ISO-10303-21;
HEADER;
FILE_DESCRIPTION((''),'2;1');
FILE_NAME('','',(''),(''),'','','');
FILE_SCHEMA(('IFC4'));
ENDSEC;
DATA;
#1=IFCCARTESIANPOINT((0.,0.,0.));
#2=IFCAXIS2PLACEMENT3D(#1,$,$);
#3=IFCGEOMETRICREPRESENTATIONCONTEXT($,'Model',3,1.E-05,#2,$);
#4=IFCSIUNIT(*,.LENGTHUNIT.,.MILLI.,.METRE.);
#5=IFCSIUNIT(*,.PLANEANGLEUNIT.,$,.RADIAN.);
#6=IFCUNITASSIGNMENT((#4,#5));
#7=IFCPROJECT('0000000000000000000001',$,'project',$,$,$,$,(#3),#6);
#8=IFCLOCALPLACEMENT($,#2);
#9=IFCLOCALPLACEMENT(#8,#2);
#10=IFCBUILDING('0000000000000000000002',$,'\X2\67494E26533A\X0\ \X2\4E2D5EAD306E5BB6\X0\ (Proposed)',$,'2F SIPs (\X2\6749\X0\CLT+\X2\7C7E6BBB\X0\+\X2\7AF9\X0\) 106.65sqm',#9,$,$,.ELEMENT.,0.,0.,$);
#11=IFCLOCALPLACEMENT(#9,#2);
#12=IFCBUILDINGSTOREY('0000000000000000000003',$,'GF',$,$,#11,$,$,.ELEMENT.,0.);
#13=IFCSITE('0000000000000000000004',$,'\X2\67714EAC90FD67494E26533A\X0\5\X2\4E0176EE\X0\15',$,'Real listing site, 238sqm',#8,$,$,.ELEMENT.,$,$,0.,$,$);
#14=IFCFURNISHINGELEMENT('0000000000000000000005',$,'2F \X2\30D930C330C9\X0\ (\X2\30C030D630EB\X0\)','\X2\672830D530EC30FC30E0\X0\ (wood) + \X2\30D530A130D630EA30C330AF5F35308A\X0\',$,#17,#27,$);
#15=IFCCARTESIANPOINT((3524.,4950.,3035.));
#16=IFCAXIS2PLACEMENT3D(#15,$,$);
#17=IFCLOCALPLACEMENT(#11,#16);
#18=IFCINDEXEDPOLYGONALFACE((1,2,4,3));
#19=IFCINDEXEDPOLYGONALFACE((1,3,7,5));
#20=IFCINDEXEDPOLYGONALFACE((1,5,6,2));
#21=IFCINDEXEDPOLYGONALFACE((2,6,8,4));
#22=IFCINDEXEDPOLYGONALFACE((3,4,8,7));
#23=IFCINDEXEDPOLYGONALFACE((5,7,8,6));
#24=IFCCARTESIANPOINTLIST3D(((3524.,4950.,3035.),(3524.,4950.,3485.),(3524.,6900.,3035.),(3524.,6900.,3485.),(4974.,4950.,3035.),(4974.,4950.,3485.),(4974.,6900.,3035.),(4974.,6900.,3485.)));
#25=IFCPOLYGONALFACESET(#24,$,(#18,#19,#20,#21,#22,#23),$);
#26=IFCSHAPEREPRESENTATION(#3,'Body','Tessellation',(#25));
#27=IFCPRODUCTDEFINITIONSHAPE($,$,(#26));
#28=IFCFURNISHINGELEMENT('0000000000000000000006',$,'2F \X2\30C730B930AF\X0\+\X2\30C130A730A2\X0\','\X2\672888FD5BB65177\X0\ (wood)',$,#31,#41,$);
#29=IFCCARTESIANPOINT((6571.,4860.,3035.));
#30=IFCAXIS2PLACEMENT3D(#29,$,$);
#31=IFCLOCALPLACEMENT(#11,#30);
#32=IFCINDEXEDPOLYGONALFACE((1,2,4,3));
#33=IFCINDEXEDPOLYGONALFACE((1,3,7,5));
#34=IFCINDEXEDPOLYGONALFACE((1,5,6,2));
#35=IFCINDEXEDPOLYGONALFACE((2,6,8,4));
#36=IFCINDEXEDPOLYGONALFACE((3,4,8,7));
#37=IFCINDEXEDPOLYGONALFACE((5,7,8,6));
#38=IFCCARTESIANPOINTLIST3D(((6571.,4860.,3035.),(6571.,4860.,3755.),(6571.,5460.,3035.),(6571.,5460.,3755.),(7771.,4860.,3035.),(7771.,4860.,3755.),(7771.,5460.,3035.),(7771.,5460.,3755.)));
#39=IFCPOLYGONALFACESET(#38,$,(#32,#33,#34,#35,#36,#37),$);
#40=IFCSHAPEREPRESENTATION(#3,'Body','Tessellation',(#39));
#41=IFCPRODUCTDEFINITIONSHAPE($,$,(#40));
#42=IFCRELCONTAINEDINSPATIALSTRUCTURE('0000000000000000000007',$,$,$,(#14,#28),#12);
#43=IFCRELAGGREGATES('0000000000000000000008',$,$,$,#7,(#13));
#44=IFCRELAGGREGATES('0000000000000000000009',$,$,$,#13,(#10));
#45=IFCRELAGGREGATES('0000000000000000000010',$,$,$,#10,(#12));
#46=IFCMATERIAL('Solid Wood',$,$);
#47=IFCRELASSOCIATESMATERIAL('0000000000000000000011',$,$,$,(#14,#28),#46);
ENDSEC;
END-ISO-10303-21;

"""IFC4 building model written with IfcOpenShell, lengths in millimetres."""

from ifc_helpers import new_model, si_unit, frame, frame_2d, origin, place, context, project, spatial, rectangle, extrude, material, element, save


model = new_model("IFC4")

# Units and contexts
model_context = context("Model", 3, precision=1e-05, world=origin())
ifc_project = project(units=[si_unit("LENGTHUNIT", "METRE", prefix="MILLI"), si_unit("PLANEANGLEUNIT", "RADIAN")], contexts=[model_context])

# Site, building, storey
site_placement = place(None, origin())
site = spatial("IfcSite", under=ifc_project, at=site_placement, Name="東京都杉並区5丁目15", ObjectType="Real listing site, 238sqm", CompositionType="ELEMENT", RefElevation=0.0)
building_placement = place(site_placement, origin())
building = spatial("IfcBuilding", under=site, at=building_placement, Name="杉並区 中庭の家 (Proposed)", ObjectType="2F SIPs (杉CLT+籾殻+竹) 106.65sqm", CompositionType="ELEMENT", ElevationOfRefHeight=0.0, ElevationOfTerrain=0.0)
storey_placement = place(building_placement, origin())
storey = spatial("IfcBuildingStorey", under=building, at=storey_placement, Name="GF", CompositionType="ELEMENT", Elevation=0.0)

# Shared definitions
ifc_material_1 = material(Name="Solid Wood")

# Furnishing elements
furnishing_1_placement = place(storey_placement, frame((3524.0, 4950.0, 3035.0)))
element("IfcFurnishingElement", 1, at=furnishing_1_placement, inside=storey, material=ifc_material_1, Name="2F ベッド (ダブル)", Description="木フレーム (wood) + ファブリック張り", context=model_context, shape_type="SweptSolid", body=[
    extrude(rectangle(XDim=1450.0, YDim=1950.0, at=frame_2d((725.0, 975.0))), frame((3524.0, 4950.0, 3035.0)), (0.0, 0.0, 1.0), 450.0),
])
furnishing_2_placement = place(storey_placement, frame((6571.0, 4860.0, 3035.0)))
element("IfcFurnishingElement", 2, at=furnishing_2_placement, inside=storey, material=ifc_material_1, Name="2F デスク+チェア", Description="木製家具 (wood)", context=model_context, shape_type="SweptSolid", body=[
    extrude(rectangle(XDim=1200.0, YDim=600.0, at=frame_2d((600.0, 300.0))), frame((6571.0, 4860.0, 3035.0)), (0.0, 0.0, 1.0), 720.0),
])

save(model, "model.ifc")
